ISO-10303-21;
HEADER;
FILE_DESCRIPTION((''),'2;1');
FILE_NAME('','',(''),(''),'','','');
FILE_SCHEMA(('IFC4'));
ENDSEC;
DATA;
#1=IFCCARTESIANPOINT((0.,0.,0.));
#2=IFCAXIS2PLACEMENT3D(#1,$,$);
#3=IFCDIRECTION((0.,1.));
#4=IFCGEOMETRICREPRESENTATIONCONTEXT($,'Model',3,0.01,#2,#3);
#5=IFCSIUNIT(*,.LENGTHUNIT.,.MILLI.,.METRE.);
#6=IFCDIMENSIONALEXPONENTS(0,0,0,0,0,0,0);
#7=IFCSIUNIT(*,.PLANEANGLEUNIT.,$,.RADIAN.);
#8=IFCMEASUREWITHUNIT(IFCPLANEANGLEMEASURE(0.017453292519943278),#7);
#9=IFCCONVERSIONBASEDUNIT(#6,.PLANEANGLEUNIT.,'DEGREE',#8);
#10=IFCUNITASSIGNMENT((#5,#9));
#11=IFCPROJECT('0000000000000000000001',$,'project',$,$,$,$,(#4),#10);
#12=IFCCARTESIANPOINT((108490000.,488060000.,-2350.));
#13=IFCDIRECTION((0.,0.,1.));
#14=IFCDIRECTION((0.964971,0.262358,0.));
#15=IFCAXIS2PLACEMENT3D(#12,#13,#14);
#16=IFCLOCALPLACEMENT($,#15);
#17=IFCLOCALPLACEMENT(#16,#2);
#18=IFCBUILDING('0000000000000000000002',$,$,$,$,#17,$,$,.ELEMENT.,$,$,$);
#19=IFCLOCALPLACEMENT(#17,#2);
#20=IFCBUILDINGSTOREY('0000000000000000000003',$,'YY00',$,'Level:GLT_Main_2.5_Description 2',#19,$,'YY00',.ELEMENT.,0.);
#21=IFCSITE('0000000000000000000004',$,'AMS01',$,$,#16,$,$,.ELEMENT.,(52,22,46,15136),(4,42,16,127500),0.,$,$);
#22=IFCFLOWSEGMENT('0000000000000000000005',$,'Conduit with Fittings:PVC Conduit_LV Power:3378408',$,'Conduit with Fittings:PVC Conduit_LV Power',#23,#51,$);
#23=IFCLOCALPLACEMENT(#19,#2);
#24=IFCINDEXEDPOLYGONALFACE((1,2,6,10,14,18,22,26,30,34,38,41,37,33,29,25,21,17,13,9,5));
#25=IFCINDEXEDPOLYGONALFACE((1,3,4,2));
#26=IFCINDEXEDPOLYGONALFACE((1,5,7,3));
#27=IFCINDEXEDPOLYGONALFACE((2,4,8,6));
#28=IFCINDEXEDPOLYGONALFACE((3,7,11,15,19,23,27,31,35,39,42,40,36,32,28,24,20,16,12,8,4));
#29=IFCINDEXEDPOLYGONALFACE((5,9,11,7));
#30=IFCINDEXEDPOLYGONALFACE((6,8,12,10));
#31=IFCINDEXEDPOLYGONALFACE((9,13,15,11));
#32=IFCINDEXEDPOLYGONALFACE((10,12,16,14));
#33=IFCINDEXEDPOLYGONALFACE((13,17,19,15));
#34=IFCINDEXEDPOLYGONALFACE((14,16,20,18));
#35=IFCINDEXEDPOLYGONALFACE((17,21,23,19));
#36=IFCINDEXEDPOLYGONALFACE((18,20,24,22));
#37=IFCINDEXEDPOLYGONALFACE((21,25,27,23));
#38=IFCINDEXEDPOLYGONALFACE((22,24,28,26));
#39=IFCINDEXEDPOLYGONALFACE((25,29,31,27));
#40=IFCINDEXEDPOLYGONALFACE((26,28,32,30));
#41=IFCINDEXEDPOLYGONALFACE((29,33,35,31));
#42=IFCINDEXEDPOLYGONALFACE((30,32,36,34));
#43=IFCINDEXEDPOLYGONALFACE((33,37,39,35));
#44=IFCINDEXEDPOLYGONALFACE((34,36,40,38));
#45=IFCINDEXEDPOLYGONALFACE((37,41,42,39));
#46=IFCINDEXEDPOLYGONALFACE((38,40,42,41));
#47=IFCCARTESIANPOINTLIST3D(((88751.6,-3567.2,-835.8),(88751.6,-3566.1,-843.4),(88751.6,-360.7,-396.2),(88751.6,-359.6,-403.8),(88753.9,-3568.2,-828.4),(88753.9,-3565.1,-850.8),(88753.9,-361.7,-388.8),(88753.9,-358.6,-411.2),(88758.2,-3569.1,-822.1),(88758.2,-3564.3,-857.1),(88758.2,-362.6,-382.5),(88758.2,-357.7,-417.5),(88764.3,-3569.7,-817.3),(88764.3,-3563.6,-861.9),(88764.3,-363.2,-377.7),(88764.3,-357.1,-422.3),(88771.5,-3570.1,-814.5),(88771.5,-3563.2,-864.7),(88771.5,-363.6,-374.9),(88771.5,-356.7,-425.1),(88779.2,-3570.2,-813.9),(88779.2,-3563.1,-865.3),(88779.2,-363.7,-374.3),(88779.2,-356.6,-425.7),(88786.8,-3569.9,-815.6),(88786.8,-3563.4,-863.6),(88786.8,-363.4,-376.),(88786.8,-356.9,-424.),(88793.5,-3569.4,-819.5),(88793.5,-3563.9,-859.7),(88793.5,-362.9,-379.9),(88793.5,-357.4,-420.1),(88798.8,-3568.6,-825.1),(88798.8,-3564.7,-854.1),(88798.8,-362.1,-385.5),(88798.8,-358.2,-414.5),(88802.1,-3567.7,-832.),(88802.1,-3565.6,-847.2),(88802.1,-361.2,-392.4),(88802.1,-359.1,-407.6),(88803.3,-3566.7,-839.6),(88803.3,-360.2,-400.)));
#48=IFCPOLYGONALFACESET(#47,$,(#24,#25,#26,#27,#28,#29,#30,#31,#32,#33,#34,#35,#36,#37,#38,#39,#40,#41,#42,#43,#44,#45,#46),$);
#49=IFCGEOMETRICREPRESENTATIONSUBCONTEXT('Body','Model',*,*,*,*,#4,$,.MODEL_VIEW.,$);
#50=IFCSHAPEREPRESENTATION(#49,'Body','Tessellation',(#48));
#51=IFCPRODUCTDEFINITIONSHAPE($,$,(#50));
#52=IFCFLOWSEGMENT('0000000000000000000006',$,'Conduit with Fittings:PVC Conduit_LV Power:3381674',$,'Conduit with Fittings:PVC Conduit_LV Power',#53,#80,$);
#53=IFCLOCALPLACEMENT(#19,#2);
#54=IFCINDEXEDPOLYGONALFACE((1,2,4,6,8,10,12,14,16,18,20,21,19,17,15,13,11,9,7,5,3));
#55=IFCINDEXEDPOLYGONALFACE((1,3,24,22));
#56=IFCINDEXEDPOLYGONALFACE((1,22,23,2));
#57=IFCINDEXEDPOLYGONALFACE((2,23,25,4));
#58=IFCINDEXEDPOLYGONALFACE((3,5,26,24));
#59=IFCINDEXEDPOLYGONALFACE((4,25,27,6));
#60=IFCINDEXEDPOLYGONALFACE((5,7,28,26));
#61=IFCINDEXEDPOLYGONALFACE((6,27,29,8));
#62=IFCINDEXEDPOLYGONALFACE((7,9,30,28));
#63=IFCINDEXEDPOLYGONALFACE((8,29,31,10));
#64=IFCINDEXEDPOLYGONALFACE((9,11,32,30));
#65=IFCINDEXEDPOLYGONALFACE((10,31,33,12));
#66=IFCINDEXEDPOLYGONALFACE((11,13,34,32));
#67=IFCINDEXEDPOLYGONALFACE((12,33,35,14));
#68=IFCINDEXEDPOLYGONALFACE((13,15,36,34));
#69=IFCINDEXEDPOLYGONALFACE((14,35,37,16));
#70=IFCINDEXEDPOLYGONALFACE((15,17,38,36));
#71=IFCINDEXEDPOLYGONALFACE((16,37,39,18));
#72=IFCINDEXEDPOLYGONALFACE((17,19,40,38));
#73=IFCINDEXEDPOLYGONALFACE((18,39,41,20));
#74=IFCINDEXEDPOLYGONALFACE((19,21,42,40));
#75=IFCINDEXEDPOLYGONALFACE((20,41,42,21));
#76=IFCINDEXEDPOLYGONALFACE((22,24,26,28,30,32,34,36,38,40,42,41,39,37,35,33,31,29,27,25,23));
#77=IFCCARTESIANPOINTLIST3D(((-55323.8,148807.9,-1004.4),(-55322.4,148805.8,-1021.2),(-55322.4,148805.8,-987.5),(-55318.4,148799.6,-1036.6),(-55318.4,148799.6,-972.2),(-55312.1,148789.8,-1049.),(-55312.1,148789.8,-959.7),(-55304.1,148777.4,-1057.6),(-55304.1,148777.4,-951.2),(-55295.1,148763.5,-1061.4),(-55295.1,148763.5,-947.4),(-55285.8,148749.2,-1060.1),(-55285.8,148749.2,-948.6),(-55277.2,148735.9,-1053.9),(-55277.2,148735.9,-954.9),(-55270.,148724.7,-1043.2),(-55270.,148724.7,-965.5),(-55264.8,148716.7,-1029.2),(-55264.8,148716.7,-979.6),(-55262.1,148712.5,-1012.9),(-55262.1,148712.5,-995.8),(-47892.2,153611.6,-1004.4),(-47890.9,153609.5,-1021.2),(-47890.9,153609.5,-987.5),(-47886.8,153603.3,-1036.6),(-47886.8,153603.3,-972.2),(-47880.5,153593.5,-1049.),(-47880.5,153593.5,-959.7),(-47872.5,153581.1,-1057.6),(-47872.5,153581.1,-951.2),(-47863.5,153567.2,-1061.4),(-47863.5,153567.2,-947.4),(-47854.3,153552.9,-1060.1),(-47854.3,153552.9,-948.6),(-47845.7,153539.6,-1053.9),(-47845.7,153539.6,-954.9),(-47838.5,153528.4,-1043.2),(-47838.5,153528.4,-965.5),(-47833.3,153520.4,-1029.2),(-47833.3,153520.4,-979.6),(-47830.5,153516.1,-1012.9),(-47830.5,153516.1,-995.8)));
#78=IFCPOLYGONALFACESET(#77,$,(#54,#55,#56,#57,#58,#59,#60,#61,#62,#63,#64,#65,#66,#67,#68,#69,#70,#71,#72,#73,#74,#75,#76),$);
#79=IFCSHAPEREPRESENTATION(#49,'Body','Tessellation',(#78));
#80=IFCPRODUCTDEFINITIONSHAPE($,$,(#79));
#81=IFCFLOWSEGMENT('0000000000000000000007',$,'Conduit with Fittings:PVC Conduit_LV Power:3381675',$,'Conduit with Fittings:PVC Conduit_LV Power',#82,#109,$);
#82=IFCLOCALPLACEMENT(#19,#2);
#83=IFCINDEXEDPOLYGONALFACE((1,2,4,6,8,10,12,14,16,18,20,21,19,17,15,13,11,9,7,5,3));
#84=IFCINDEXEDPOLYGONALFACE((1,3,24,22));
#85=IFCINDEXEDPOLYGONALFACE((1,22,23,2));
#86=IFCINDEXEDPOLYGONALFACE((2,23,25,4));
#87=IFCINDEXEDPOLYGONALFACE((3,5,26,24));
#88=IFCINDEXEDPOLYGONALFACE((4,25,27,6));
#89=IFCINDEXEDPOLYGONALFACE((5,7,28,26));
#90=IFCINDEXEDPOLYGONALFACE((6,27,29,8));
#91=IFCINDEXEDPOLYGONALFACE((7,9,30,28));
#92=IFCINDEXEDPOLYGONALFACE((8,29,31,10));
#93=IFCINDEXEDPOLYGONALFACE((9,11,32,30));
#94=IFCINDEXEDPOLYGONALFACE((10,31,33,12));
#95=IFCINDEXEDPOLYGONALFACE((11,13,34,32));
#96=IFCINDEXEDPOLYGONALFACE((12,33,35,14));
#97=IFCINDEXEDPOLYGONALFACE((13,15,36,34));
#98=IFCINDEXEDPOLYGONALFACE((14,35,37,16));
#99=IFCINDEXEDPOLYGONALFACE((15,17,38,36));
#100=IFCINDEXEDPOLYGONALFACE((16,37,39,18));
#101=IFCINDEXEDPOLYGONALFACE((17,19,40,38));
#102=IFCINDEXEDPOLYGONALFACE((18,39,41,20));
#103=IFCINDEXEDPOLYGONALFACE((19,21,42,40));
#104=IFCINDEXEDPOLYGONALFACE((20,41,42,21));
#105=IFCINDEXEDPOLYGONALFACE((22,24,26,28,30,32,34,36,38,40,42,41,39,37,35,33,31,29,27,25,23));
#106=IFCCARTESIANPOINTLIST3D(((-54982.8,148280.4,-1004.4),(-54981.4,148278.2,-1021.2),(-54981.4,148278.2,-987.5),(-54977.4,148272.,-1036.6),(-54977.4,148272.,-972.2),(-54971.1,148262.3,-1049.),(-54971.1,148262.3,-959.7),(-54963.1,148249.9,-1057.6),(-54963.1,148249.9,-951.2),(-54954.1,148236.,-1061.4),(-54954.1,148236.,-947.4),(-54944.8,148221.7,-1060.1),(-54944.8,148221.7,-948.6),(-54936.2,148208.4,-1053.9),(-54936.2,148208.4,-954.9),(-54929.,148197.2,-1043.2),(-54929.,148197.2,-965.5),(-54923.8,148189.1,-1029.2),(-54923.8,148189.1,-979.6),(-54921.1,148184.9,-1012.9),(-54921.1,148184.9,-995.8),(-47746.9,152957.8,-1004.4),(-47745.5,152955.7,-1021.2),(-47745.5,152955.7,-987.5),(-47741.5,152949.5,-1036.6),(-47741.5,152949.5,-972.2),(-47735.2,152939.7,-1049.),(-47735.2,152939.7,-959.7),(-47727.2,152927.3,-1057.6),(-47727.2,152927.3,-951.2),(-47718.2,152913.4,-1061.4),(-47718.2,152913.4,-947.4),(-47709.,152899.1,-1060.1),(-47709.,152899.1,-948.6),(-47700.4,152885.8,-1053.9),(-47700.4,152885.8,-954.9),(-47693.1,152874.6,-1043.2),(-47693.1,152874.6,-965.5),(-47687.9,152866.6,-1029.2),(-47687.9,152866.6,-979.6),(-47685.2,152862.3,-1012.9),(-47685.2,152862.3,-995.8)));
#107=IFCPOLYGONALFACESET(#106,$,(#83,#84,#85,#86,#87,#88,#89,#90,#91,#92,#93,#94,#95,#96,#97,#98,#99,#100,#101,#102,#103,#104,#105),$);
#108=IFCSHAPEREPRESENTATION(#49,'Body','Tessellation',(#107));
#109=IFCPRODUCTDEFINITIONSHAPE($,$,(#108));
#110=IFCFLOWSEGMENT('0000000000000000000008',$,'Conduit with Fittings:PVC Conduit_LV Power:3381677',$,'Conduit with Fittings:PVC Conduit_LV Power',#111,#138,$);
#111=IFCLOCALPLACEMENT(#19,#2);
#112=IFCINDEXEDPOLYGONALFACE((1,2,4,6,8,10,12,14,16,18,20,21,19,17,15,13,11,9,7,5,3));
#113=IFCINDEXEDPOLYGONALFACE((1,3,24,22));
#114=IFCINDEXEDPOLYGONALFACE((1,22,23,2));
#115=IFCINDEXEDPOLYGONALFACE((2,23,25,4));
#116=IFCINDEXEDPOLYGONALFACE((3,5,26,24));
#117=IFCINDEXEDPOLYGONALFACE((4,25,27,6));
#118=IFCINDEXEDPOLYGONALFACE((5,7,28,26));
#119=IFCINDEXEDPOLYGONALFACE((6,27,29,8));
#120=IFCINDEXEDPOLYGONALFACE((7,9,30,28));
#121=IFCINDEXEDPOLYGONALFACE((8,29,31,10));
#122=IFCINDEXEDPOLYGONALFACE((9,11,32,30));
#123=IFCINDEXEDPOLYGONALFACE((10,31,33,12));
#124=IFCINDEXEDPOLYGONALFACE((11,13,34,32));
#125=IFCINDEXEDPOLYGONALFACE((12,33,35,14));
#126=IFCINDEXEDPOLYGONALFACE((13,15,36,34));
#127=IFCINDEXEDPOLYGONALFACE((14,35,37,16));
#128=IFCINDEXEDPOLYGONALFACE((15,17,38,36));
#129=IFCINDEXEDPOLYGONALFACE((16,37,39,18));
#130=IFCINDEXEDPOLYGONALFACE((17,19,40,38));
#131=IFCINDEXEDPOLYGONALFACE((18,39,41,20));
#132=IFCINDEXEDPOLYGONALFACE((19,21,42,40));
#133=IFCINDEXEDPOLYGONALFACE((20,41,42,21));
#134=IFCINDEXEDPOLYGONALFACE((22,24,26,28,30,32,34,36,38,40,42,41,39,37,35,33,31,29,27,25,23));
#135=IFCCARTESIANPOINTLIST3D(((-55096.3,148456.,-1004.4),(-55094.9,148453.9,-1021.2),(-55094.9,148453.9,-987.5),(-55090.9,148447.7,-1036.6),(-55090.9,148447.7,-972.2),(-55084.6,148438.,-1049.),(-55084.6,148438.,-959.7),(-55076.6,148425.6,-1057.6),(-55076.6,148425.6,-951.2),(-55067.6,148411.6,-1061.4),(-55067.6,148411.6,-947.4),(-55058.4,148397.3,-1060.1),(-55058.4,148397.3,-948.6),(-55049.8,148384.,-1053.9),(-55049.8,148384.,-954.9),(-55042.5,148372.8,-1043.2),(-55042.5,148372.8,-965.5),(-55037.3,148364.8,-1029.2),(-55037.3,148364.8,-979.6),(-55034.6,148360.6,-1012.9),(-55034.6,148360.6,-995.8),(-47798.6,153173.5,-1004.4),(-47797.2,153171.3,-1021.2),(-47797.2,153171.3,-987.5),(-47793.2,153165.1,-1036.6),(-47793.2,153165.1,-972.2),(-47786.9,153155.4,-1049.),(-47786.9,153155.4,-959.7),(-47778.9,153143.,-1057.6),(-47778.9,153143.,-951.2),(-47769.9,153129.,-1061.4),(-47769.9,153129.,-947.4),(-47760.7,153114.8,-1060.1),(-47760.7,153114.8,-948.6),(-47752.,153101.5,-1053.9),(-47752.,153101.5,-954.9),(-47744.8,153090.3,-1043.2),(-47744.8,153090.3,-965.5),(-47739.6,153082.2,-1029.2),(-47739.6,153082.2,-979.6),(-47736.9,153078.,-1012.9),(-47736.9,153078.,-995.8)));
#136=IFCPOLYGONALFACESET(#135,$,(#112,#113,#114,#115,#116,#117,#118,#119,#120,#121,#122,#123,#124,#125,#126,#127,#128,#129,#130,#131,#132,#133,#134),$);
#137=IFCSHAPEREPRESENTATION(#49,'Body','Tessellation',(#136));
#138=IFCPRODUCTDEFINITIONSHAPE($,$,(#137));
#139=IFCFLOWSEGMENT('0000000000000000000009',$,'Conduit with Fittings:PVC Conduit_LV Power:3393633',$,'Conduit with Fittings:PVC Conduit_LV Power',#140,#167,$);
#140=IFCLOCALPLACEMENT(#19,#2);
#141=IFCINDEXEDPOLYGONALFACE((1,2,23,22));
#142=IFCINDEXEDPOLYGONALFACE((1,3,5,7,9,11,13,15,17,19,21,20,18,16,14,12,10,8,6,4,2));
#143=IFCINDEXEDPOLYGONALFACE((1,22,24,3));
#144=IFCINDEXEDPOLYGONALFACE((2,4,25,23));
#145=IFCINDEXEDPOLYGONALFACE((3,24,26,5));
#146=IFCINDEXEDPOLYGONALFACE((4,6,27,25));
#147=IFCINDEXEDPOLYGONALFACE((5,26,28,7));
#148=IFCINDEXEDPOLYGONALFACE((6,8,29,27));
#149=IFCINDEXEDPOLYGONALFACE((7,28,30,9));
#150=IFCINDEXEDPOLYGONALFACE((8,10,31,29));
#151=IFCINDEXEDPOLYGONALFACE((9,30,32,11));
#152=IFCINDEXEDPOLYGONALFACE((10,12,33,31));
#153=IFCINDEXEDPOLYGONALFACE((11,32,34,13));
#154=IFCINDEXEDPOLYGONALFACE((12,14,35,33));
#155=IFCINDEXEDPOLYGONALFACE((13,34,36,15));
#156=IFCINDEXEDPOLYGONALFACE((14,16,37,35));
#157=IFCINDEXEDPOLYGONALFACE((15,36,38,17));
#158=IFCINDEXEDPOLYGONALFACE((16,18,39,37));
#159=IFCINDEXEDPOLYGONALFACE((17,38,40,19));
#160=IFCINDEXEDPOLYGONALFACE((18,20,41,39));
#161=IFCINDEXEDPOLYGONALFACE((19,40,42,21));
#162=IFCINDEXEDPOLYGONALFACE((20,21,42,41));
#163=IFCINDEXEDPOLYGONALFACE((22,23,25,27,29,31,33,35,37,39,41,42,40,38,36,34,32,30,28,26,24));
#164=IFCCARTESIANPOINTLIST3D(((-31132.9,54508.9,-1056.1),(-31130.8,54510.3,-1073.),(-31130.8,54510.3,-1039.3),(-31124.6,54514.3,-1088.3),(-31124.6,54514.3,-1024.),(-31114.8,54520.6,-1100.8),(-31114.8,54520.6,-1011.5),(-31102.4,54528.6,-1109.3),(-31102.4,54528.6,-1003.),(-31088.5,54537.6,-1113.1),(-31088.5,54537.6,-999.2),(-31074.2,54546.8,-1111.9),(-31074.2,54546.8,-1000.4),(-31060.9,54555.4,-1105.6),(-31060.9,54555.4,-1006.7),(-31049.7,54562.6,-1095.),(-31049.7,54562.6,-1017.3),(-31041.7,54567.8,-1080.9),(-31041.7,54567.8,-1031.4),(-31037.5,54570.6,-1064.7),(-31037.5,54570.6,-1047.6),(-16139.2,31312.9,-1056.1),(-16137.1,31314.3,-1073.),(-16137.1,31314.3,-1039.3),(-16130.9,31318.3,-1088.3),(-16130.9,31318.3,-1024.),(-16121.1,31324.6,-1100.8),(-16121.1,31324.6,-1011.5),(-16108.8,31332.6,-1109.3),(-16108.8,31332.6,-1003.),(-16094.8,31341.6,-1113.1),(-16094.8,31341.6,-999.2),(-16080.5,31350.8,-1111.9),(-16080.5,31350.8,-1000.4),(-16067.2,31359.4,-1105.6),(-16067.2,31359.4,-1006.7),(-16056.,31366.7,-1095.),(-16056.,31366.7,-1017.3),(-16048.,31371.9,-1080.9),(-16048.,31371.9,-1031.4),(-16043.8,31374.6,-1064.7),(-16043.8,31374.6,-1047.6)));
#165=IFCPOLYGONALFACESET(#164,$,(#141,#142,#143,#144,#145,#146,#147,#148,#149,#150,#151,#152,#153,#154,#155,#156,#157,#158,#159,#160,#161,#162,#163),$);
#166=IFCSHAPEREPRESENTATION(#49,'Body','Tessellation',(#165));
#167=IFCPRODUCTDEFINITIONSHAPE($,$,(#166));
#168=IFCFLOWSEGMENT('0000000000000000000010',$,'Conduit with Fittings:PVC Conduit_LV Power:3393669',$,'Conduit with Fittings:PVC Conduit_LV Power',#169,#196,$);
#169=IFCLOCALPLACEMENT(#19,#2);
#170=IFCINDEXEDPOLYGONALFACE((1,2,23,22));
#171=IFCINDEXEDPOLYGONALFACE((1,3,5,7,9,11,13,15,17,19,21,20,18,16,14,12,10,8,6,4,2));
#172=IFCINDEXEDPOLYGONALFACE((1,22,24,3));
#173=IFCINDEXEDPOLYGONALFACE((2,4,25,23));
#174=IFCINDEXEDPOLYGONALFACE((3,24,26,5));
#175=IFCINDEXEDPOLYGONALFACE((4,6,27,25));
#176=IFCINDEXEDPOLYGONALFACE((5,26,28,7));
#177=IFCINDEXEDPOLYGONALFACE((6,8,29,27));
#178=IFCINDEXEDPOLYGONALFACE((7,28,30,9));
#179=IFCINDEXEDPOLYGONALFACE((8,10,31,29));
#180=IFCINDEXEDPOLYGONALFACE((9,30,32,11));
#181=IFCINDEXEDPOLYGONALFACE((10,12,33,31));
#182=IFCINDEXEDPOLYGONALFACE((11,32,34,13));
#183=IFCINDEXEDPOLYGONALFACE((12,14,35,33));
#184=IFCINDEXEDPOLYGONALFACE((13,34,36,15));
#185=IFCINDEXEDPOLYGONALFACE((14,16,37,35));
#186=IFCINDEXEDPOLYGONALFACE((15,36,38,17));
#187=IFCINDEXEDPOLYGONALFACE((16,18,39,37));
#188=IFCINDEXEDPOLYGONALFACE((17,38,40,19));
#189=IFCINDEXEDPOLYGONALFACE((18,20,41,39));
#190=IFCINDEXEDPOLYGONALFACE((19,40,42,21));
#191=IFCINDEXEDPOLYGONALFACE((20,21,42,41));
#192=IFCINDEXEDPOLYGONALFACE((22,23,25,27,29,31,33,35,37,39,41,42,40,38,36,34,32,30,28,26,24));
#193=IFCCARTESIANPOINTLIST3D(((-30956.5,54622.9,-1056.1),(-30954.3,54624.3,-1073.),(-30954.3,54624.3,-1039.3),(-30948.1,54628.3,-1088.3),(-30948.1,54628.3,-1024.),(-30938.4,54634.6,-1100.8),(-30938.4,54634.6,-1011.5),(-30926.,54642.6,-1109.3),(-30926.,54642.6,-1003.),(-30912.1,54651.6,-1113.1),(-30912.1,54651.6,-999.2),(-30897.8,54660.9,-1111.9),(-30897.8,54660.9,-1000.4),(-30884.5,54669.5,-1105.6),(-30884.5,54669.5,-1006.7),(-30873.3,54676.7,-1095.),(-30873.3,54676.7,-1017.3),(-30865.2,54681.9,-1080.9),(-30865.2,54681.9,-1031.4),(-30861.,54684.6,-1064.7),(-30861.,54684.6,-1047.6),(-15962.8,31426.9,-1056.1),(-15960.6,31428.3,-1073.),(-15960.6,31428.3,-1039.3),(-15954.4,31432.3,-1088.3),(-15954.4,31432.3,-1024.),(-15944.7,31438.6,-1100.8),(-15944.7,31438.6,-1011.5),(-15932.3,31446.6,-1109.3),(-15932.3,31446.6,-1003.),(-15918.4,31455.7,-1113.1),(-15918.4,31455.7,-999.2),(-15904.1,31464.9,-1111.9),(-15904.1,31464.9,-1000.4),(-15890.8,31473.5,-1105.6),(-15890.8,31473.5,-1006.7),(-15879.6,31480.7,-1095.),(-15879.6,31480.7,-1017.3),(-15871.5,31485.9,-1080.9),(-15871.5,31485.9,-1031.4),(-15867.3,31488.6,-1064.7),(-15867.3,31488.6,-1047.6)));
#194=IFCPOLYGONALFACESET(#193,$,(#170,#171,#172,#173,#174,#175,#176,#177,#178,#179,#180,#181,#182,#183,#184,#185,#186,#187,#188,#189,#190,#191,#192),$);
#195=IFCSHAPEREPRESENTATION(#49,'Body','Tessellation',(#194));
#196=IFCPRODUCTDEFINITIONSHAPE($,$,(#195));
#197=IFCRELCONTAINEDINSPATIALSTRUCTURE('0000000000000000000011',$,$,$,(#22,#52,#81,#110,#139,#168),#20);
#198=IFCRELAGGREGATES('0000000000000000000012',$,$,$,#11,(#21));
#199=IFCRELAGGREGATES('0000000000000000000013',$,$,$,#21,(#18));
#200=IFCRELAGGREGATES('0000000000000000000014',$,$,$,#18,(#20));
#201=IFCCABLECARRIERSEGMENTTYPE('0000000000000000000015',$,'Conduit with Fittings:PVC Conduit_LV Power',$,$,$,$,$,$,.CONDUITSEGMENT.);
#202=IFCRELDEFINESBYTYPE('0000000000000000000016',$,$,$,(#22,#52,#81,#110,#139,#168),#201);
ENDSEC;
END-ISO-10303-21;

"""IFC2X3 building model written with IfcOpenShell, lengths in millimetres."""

from ifc_helpers import new_model, entity, si_unit, converted_unit, direction, frame, frame_2d, origin, origin_2d_with_axis, place, context, subcontext, project, spatial, circle, extrude, type_object, element, save


model = new_model("IFC2X3")

# Units and contexts
model_context = context("Model", 3, precision=0.01, world=origin(), true_north=direction((0.0, 1.0)))
body_context = subcontext(model_context, "Body", "Model", "MODEL_VIEW")
ifc_project = project(units=[si_unit("LENGTHUNIT", "METRE", prefix="MILLI"), converted_unit("PLANEANGLEUNIT", "DEGREE", entity("IfcPlaneAngleMeasure", 0.017453292519943278), si_unit("PLANEANGLEUNIT", "RADIAN"), dimensions=[0, 0, 0, 0, 0, 0, 0])], contexts=[model_context])

# Site, building, storey
site_placement = place(None, frame((108490000.0, 488060000.0, -2350.0), z_axis=(0.0, 0.0, 1.0), x_axis=(0.964971, 0.262358, 0.0)))
site = spatial("IfcSite", under=ifc_project, at=site_placement, Name="AMS01", CompositionType="ELEMENT", RefLatitude=(52, 22, 46, 15136), RefLongitude=(4, 42, 16, 127500), RefElevation=0.0)
building_placement = place(site_placement, origin())
building = spatial("IfcBuilding", under=site, at=building_placement, CompositionType="ELEMENT")
storey_placement = place(building_placement, origin())
storey = spatial("IfcBuildingStorey", under=building, at=storey_placement, Name="YY00", ObjectType="Level:GLT_Main_2.5_Description 2", LongName="YY00", CompositionType="ELEMENT", Elevation=0.0)

# Flow segments
cable_carrier_segment_type = type_object("IfcCableCarrierSegmentType", Name="Conduit with Fittings:PVC Conduit_LV Power", PredefinedType="CONDUITSEGMENT")
flow_segment_1_placement = place(storey_placement, origin())
element("IfcFlowSegment", 1, at=flow_segment_1_placement, inside=storey, type_object=cable_carrier_segment_type, Name="Conduit with Fittings:PVC Conduit_LV Power:3378408", ObjectType="Conduit with Fittings:PVC Conduit_LV Power", context=body_context, shape_type="SweptSolid", body=[
    extrude(circle(Radius=26.0, at=frame_2d((0.0, 0.0), x_axis=(1.0, 0.0))), frame((88777.3, -3566.7, -839.6), z_axis=(0.0, 0.990732, 0.135829), x_axis=(1.0, 0.0, 0.0)), (0.0, 0.0, 1.0), 3236.5),
])
flow_segment_2_placement = place(storey_placement, origin())
element("IfcFlowSegment", 2, at=flow_segment_2_placement, inside=storey, type_object=cable_carrier_segment_type, Name="Conduit with Fittings:PVC Conduit_LV Power:3381674", ObjectType="Conduit with Fittings:PVC Conduit_LV Power", context=body_context, shape_type="SweptSolid", body=[
    extrude(circle(Radius=57.2, at=frame_2d((0.0, 0.0), x_axis=(1.0, 0.0))), frame((-55292.7, 148759.9, -1004.4), z_axis=(0.839826, 0.542856, 0.0), x_axis=(-0.542856, 0.839826, 0.0)), (0.0, 0.0, 1.0), 8848.9),
])
flow_segment_3_placement = place(storey_placement, origin())
element("IfcFlowSegment", 3, at=flow_segment_3_placement, inside=storey, type_object=cable_carrier_segment_type, Name="Conduit with Fittings:PVC Conduit_LV Power:3381675", ObjectType="Conduit with Fittings:PVC Conduit_LV Power", context=body_context, shape_type="SweptSolid", body=[
    extrude(circle(Radius=57.2, at=frame_2d((0.0, 0.0), x_axis=(1.0, 0.0))), frame((-54951.7, 148232.4, -1004.4), z_axis=(0.839813, 0.542876, 0.0), x_axis=(-0.542876, 0.839813, 0.0)), (0.0, 0.0, 1.0), 8616.0),
])
flow_segment_4_placement = place(storey_placement, origin())
element("IfcFlowSegment", 4, at=flow_segment_4_placement, inside=storey, type_object=cable_carrier_segment_type, Name="Conduit with Fittings:PVC Conduit_LV Power:3381677", ObjectType="Conduit with Fittings:PVC Conduit_LV Power", context=body_context, shape_type="SweptSolid", body=[
    extrude(circle(Radius=57.2, at=frame_2d((0.0, 0.0), x_axis=(1.0, 0.0))), frame((-55065.3, 148408.0, -1004.4), z_axis=(0.839813, 0.542876, 0.0), x_axis=(-0.542876, 0.839813, 0.0)), (0.0, 0.0, 1.0), 8689.7),
])
flow_segment_5_placement = place(storey_placement, origin())
element("IfcFlowSegment", 5, at=flow_segment_5_placement, inside=storey, type_object=cable_carrier_segment_type, Name="Conduit with Fittings:PVC Conduit_LV Power:3393633", ObjectType="Conduit with Fittings:PVC Conduit_LV Power", context=body_context, shape_type="SweptSolid", body=[
    extrude(circle(Radius=57.2, at=frame_2d((0.0, 0.0), x_axis=(1.0, 0.0))), frame((-16091.2, 31343.9, -1056.1), z_axis=(-0.542856, 0.839826, 0.0), x_axis=(-0.839826, -0.542856, 0.0)), (0.0, 0.0, 1.0), 27620.0),
])
flow_segment_6_placement = place(storey_placement, origin())
element("IfcFlowSegment", 6, at=flow_segment_6_placement, inside=storey, type_object=cable_carrier_segment_type, Name="Conduit with Fittings:PVC Conduit_LV Power:3393669", ObjectType="Conduit with Fittings:PVC Conduit_LV Power", context=body_context, shape_type="SweptSolid", body=[
    extrude(circle(Radius=57.2, at=origin_2d_with_axis()), frame((-30908.5, 54654.0, -1056.1), z_axis=(0.542856, -0.839826, 0.0), x_axis=(-0.839826, -0.542856, 0.0)), (0.0, 0.0, 1.0), 27620.0),
])

save(model, "model.ifc")
